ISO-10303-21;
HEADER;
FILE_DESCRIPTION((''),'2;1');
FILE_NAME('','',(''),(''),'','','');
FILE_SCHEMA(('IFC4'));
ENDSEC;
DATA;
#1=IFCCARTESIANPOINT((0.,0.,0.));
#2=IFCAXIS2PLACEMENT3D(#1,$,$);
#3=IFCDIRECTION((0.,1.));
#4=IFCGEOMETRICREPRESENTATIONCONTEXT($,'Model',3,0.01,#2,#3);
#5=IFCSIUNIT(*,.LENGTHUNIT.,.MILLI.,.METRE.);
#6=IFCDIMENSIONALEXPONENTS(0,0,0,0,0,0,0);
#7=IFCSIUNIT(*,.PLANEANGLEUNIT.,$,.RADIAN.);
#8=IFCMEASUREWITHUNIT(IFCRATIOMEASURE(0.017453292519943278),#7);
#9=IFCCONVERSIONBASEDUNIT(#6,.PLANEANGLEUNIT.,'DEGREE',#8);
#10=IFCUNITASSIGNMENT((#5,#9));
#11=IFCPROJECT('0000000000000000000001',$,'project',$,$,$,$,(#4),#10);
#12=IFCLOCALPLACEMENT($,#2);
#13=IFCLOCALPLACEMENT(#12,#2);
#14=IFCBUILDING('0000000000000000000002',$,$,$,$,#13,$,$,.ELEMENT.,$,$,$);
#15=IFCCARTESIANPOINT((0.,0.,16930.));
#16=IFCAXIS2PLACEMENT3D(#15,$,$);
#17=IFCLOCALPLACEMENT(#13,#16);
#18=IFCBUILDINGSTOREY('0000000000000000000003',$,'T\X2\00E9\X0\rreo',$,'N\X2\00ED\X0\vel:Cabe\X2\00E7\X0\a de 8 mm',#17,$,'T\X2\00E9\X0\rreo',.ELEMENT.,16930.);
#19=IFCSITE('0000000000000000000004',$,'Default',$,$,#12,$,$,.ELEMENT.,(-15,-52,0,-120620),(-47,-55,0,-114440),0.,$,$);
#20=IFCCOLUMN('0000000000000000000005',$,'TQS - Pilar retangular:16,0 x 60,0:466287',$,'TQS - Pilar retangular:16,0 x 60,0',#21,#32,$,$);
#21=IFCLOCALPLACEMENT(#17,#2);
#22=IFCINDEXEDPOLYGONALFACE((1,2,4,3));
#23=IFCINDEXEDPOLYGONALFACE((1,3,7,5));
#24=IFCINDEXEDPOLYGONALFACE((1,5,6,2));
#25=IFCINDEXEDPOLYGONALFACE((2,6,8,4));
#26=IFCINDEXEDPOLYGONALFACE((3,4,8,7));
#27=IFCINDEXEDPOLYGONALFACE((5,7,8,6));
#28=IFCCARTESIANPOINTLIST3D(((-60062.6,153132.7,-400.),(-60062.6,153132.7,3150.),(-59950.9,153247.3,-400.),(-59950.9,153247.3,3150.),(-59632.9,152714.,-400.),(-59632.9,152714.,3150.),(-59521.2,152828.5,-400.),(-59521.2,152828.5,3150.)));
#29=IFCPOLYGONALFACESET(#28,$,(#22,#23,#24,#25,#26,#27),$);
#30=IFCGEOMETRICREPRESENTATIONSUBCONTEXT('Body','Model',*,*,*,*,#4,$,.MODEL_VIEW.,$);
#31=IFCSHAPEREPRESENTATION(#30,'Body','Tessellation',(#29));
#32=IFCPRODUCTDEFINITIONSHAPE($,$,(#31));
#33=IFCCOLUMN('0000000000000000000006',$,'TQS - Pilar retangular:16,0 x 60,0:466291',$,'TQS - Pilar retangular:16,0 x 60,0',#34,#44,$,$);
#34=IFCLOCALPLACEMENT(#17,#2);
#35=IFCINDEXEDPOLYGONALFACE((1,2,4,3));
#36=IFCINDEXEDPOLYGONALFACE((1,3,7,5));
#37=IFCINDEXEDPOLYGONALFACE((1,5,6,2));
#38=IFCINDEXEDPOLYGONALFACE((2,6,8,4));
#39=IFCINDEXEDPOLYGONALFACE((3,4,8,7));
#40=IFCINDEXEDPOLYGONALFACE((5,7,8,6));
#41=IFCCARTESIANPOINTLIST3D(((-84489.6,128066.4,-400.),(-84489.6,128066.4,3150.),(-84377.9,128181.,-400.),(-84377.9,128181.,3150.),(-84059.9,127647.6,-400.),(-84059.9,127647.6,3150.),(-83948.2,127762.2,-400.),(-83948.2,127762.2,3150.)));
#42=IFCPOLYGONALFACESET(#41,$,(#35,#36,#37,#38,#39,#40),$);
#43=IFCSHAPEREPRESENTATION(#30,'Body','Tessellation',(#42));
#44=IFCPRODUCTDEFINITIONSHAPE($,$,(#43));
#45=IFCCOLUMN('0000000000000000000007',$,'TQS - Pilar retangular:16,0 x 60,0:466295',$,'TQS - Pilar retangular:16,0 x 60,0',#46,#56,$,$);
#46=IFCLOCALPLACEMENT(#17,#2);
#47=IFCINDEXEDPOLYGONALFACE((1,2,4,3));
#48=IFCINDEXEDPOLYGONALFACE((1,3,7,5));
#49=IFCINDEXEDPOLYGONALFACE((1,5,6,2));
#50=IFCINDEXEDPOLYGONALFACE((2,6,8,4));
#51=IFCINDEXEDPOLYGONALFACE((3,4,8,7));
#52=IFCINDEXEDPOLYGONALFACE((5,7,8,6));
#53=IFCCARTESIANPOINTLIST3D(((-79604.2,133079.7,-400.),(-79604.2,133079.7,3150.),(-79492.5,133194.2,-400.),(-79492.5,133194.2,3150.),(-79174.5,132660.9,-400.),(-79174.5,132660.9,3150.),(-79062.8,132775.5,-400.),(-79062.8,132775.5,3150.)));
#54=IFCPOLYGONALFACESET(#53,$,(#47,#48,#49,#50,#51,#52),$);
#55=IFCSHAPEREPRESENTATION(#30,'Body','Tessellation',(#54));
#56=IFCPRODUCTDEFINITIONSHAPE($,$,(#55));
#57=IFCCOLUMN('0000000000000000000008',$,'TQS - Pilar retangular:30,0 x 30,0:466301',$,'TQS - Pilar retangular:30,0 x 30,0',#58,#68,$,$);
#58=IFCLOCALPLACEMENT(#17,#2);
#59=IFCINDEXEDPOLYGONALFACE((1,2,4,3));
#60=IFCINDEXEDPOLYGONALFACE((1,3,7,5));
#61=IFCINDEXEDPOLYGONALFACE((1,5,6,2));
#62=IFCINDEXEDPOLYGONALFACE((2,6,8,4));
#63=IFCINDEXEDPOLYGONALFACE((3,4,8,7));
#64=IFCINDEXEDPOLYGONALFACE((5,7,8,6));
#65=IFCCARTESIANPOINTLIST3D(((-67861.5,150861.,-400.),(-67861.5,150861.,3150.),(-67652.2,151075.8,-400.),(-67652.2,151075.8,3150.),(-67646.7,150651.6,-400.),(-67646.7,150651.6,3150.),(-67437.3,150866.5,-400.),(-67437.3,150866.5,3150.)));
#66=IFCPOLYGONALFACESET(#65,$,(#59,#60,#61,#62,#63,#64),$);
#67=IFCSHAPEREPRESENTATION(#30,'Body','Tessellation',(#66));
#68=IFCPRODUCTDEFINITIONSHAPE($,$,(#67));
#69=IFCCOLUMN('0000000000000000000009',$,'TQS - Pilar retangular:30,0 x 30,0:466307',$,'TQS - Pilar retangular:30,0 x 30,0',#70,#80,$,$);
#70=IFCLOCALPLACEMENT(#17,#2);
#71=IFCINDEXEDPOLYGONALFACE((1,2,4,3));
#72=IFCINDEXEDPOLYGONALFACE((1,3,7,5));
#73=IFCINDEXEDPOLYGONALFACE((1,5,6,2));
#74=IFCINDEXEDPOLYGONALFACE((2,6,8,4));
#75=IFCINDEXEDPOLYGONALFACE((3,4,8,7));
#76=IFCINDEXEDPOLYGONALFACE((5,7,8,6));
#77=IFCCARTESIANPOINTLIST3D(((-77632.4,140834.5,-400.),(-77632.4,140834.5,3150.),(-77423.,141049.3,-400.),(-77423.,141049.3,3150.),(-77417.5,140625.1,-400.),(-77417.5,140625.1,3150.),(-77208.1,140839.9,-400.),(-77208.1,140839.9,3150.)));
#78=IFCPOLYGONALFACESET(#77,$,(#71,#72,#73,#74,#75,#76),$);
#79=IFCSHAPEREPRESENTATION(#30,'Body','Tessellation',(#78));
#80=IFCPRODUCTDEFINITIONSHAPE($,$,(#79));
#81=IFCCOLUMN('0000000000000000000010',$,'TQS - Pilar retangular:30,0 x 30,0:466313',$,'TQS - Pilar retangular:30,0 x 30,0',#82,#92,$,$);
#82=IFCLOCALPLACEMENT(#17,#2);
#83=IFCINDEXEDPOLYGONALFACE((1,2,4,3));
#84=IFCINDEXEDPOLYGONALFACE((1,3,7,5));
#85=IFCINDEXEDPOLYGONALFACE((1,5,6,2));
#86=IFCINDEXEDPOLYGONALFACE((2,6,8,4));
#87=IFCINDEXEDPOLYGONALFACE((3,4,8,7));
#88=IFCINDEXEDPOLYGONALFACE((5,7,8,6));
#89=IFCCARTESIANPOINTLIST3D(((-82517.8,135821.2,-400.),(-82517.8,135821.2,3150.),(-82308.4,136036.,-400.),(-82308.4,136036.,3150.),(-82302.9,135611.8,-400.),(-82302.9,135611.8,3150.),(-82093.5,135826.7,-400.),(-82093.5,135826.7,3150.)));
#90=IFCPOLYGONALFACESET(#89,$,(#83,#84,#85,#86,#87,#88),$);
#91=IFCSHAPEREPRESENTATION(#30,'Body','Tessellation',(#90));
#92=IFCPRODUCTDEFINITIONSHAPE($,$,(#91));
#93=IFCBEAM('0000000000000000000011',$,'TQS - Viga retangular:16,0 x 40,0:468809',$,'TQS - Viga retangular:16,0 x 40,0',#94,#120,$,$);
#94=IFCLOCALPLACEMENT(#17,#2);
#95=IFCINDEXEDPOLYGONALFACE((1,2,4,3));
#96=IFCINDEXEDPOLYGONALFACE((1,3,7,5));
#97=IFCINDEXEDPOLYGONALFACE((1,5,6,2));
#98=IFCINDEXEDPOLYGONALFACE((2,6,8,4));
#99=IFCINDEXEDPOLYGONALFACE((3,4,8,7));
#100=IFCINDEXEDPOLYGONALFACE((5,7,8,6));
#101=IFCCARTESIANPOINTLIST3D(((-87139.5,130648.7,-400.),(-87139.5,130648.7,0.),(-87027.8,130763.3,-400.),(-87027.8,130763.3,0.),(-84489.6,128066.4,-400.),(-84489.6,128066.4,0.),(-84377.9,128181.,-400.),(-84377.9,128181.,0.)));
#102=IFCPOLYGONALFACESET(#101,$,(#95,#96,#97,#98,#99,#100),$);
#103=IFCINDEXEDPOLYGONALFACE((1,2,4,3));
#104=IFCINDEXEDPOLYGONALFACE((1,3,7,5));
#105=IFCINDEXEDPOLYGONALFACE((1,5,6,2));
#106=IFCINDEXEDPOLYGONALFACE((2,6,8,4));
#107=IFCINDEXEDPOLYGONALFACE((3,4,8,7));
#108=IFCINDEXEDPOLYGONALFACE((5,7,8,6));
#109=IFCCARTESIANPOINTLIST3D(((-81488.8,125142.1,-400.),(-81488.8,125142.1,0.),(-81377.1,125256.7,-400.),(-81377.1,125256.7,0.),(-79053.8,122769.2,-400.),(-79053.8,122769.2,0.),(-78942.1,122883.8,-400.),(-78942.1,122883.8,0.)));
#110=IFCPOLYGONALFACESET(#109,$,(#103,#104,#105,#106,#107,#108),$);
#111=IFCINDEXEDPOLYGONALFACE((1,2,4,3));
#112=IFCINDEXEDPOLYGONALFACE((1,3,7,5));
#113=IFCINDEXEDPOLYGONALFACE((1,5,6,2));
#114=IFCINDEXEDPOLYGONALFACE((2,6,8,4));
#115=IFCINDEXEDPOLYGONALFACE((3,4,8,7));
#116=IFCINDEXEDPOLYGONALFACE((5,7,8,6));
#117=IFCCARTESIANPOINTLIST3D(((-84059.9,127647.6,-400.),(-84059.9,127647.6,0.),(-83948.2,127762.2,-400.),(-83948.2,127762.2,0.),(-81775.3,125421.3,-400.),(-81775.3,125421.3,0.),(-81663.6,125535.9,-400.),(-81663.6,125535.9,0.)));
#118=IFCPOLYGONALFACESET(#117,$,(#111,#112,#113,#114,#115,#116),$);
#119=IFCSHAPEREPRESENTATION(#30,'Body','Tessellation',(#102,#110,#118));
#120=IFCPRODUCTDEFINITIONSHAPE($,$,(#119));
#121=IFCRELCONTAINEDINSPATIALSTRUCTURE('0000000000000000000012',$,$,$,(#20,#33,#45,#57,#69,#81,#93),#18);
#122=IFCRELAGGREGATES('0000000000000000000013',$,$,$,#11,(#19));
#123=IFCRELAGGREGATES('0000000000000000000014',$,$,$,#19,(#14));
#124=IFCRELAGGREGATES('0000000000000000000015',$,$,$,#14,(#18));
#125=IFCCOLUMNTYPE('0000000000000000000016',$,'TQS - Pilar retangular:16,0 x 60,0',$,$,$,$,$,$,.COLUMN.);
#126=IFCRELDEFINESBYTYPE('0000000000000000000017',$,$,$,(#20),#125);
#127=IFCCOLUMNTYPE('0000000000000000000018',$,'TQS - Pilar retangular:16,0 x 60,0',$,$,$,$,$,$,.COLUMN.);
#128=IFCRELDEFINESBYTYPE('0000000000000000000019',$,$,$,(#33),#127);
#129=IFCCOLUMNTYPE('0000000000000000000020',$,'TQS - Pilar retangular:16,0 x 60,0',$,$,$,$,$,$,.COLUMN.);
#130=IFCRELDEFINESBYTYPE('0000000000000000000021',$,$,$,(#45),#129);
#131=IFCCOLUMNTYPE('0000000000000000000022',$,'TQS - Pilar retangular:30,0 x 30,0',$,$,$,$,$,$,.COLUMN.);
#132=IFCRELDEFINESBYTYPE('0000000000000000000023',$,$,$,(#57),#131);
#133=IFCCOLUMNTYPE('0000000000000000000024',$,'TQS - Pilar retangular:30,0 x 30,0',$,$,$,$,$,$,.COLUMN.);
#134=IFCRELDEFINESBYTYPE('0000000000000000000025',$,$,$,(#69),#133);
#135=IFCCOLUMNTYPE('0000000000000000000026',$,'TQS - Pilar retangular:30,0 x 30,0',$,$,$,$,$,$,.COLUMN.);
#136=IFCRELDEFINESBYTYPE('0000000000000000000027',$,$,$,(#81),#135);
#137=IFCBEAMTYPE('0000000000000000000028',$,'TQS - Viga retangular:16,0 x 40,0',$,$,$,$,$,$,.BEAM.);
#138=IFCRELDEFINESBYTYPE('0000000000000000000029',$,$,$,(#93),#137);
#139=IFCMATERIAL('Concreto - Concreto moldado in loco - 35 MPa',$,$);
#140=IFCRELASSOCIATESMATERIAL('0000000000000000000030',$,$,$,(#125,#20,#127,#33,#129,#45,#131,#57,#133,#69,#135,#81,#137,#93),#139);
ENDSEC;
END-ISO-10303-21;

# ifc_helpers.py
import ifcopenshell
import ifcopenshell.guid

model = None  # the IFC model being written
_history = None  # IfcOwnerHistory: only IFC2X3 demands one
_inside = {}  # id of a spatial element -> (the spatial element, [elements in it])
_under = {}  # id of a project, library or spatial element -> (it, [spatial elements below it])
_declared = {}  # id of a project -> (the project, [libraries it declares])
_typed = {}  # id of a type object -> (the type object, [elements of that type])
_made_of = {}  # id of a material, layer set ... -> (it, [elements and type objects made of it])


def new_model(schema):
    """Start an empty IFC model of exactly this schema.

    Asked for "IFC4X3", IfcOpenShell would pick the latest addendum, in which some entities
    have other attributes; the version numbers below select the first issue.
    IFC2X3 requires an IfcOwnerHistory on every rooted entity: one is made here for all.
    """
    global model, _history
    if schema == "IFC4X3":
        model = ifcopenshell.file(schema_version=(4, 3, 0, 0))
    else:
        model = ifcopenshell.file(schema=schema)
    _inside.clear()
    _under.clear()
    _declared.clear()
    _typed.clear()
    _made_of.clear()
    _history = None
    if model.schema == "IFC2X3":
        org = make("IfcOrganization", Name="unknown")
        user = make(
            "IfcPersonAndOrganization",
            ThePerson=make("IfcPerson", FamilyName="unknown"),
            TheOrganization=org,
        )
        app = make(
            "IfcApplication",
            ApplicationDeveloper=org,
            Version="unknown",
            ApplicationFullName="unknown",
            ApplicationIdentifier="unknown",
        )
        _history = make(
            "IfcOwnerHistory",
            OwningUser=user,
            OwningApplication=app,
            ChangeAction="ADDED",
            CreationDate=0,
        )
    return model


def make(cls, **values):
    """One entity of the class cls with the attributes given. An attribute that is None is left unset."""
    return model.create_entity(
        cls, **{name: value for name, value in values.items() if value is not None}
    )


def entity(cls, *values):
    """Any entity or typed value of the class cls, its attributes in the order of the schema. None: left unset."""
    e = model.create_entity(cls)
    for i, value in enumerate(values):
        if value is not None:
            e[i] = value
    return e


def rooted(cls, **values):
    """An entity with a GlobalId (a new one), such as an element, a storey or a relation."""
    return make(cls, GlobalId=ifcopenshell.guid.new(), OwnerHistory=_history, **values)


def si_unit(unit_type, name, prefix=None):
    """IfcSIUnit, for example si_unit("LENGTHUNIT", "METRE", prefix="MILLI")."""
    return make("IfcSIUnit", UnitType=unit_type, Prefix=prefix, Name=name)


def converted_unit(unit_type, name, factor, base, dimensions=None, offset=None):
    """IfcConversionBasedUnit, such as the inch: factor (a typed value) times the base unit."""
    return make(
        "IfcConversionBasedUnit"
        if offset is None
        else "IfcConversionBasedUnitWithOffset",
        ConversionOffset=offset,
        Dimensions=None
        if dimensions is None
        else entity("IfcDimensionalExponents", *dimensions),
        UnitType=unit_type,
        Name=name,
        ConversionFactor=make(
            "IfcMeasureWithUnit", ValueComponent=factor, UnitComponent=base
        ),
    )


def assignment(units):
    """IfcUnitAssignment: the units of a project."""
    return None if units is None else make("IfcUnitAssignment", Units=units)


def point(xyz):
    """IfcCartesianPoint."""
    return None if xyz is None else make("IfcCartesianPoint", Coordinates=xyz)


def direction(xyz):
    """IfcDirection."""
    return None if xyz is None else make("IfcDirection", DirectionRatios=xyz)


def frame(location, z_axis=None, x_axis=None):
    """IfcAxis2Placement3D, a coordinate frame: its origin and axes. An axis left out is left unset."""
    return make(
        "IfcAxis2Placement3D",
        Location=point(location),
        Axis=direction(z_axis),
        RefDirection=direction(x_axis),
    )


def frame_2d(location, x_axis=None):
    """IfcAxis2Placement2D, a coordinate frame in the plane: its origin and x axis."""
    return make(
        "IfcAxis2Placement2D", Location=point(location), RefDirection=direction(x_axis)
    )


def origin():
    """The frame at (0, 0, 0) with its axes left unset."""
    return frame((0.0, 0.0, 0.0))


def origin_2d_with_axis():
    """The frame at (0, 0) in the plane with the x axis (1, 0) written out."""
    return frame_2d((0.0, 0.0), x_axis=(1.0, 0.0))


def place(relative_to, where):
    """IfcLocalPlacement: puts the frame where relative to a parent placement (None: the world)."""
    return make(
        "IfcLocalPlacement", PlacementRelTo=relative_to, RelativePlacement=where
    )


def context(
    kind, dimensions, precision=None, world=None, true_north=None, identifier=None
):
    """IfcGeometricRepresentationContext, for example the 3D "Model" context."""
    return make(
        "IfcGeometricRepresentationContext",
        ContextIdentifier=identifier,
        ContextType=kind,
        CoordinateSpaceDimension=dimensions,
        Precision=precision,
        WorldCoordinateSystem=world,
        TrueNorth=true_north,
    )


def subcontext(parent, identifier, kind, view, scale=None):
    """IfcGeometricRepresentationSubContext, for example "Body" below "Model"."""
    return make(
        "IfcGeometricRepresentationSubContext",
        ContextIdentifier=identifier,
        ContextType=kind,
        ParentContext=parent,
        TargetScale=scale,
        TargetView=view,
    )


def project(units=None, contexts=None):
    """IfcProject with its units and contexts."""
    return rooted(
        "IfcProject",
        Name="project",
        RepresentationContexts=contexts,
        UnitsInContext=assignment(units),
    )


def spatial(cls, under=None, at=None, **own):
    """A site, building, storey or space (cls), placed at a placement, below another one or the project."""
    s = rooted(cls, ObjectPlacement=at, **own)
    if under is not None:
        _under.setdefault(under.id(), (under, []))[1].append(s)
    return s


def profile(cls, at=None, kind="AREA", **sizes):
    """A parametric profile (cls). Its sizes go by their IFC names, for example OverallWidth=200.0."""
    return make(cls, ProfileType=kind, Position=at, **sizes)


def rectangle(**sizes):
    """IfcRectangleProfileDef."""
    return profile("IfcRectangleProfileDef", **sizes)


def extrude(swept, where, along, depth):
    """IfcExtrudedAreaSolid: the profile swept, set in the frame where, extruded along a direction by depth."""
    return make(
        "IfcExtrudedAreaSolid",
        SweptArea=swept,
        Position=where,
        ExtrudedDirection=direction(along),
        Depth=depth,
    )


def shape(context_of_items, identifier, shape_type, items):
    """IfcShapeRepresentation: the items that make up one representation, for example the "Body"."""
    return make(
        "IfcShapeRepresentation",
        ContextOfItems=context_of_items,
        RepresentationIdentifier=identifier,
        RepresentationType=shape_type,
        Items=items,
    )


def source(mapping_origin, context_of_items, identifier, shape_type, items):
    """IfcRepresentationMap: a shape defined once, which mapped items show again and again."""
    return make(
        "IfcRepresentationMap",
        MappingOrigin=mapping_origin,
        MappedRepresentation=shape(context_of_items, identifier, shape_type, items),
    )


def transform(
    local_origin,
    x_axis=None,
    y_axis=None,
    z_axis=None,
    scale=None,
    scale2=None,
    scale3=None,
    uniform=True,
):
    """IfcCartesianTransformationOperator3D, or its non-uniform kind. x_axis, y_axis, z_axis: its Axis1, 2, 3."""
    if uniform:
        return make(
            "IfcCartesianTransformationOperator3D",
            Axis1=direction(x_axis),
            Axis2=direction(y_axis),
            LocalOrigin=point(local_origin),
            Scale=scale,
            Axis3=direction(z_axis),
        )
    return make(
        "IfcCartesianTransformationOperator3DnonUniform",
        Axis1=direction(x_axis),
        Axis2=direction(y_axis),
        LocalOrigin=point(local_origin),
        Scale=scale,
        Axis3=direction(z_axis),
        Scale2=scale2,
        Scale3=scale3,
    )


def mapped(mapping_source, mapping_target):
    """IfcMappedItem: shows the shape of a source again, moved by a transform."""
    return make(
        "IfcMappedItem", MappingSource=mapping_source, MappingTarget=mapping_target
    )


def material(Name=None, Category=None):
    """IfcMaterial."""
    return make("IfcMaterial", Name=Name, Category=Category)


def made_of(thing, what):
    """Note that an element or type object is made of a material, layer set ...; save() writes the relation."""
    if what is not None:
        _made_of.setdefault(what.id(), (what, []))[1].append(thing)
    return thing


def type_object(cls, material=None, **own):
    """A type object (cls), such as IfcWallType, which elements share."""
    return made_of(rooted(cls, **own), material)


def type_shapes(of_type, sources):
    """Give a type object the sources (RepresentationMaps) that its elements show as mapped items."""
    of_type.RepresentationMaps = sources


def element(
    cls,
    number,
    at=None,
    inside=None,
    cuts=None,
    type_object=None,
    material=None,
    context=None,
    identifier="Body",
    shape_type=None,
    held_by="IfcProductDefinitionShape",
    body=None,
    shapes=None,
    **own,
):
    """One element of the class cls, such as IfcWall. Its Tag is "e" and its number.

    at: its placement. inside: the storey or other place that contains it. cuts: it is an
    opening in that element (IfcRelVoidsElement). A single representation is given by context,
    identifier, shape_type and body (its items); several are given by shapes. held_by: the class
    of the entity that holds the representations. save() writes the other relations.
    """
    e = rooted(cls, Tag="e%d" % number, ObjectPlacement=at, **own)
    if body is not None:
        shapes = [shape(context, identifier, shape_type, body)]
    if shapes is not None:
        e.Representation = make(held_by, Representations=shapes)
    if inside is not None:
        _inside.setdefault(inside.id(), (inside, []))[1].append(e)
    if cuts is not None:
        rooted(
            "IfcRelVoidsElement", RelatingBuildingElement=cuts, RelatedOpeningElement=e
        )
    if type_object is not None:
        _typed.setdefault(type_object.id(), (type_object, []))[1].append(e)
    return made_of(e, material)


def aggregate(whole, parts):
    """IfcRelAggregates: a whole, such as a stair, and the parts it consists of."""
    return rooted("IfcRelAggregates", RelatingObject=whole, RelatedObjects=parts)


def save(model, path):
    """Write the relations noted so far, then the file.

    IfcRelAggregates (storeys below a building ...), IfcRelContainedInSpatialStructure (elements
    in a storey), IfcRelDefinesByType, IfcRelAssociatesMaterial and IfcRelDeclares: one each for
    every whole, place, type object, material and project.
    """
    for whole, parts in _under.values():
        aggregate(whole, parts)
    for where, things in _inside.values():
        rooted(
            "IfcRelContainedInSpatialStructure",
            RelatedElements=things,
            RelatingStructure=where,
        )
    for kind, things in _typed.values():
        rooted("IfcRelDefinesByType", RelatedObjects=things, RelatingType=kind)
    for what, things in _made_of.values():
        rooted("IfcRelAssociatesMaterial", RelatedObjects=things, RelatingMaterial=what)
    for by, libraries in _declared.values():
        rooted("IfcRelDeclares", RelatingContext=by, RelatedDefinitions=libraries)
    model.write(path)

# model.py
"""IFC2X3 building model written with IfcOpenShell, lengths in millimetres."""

from ifc_helpers import new_model, entity, si_unit, converted_unit, direction, frame, frame_2d, origin, origin_2d_with_axis, place, context, subcontext, project, spatial, rectangle, extrude, source, transform, mapped, material, type_object, type_shapes, element, save


model = new_model("IFC2X3")

# Units and contexts
model_context = context("Model", 3, precision=0.01, world=origin(), true_north=direction((0.0, 1.0)))
body_context = subcontext(model_context, "Body", "Model", "MODEL_VIEW")
ifc_project = project(units=[si_unit("LENGTHUNIT", "METRE", prefix="MILLI"), converted_unit("PLANEANGLEUNIT", "DEGREE", entity("IfcRatioMeasure", 0.017453292519943278), si_unit("PLANEANGLEUNIT", "RADIAN"), dimensions=[0, 0, 0, 0, 0, 0, 0])], contexts=[model_context])

# Site, building, storey
site_placement = place(None, origin())
site = spatial("IfcSite", under=ifc_project, at=site_placement, Name="Default", CompositionType="ELEMENT", RefLatitude=(-15, -52, 0, -120620), RefLongitude=(-47, -55, 0, -114440), RefElevation=0.0)
building_placement = place(site_placement, origin())
building = spatial("IfcBuilding", under=site, at=building_placement, CompositionType="ELEMENT")
storey_placement = place(building_placement, frame((0.0, 0.0, 16930.0)))
storey = spatial("IfcBuildingStorey", under=building, at=storey_placement, Name="Térreo", ObjectType="Nível:Cabeça de 8 mm", LongName="Térreo", CompositionType="ELEMENT", Elevation=16930.0)

# Columns
ifc_material = material(Name="Concreto - Concreto moldado in loco - 35 MPa")
column_type_1 = type_object("IfcColumnType", Name="TQS - Pilar retangular:16,0 x 60,0", PredefinedType="COLUMN", material=ifc_material)
shared_shape_1 = source(origin(), body_context, "Body", "SweptSolid", [
    extrude(rectangle(XDim=600.0, YDim=160.0, at=frame_2d((0.0, 0.0), x_axis=(1.0, 0.0))), frame((-59791.9, 152980.6, 16530.0), z_axis=(0.0, 0.0, 1.0), x_axis=(-0.71618, 0.697915, 0.0)), (0.0, 0.0, 1.0), 3550.0),
])
type_shapes(column_type_1, [shared_shape_1])
column_1_placement = place(storey_placement, frame((0.0, 0.0, -16930.0)))
element("IfcColumn", 1, at=column_1_placement, inside=storey, type_object=column_type_1, material=ifc_material, Name="TQS - Pilar retangular:16,0 x 60,0:466287", ObjectType="TQS - Pilar retangular:16,0 x 60,0", context=body_context, shape_type="MappedRepresentation", body=[
    mapped(shared_shape_1, transform((0.0, 0.0, 0.0), scale=1.0)),
])
column_type_2 = type_object("IfcColumnType", Name="TQS - Pilar retangular:16,0 x 60,0", PredefinedType="COLUMN", material=ifc_material)
shared_shape_2 = source(origin(), body_context, "Body", "SweptSolid", [
    extrude(rectangle(XDim=600.0, YDim=160.0, at=frame_2d((0.0, 0.0), x_axis=(1.0, 0.0))), frame((-84218.9, 127914.3, 16530.0), z_axis=(0.0, 0.0, 1.0), x_axis=(-0.71618, 0.697915, 0.0)), (0.0, 0.0, 1.0), 3550.0),
])
type_shapes(column_type_2, [shared_shape_2])
column_2_placement = place(storey_placement, frame((0.0, 0.0, -16930.0)))
element("IfcColumn", 2, at=column_2_placement, inside=storey, type_object=column_type_2, material=ifc_material, Name="TQS - Pilar retangular:16,0 x 60,0:466291", ObjectType="TQS - Pilar retangular:16,0 x 60,0", context=body_context, shape_type="MappedRepresentation", body=[
    mapped(shared_shape_2, transform((0.0, 0.0, 0.0), scale=1.0)),
])
column_type_3 = type_object("IfcColumnType", Name="TQS - Pilar retangular:16,0 x 60,0", PredefinedType="COLUMN", material=ifc_material)
shared_shape_3 = source(origin(), body_context, "Body", "SweptSolid", [
    extrude(rectangle(XDim=600.0, YDim=160.0, at=frame_2d((0.0, 0.0), x_axis=(1.0, 0.0))), frame((-79333.5, 132927.6, 16530.0), z_axis=(0.0, 0.0, 1.0), x_axis=(-0.71618, 0.697915, 0.0)), (0.0, 0.0, 1.0), 3550.0),
])
type_shapes(column_type_3, [shared_shape_3])
column_3_placement = place(storey_placement, frame((0.0, 0.0, -16930.0)))
element("IfcColumn", 3, at=column_3_placement, inside=storey, type_object=column_type_3, material=ifc_material, Name="TQS - Pilar retangular:16,0 x 60,0:466295", ObjectType="TQS - Pilar retangular:16,0 x 60,0", context=body_context, shape_type="MappedRepresentation", body=[
    mapped(shared_shape_3, transform((0.0, 0.0, 0.0), scale=1.0)),
])
column_type_4 = type_object("IfcColumnType", Name="TQS - Pilar retangular:30,0 x 30,0", PredefinedType="COLUMN", material=ifc_material)
shared_shape_4 = source(origin(), body_context, "Body", "SweptSolid", [
    extrude(rectangle(XDim=300.0, YDim=300.0, at=origin_2d_with_axis()), frame((-67649.4, 150863.7, 16530.0), z_axis=(0.0, 0.0, 1.0), x_axis=(-0.71618, 0.697915, 0.0)), (0.0, 0.0, 1.0), 3550.0),
])
type_shapes(column_type_4, [shared_shape_4])
column_4_placement = place(storey_placement, frame((0.0, 0.0, -16930.0)))
element("IfcColumn", 4, at=column_4_placement, inside=storey, type_object=column_type_4, material=ifc_material, Name="TQS - Pilar retangular:30,0 x 30,0:466301", ObjectType="TQS - Pilar retangular:30,0 x 30,0", context=body_context, shape_type="MappedRepresentation", body=[
    mapped(shared_shape_4, transform((0.0, 0.0, 0.0), scale=1.0)),
])
column_type_5 = type_object("IfcColumnType", Name="TQS - Pilar retangular:30,0 x 30,0", PredefinedType="COLUMN", material=ifc_material)
shared_shape_5 = source(origin(), body_context, "Body", "SweptSolid", [
    extrude(rectangle(XDim=300.0, YDim=300.0, at=origin_2d_with_axis()), frame((-77420.2, 140837.2, 16530.0), z_axis=(0.0, 0.0, 1.0), x_axis=(-0.71618, 0.697915, 0.0)), (0.0, 0.0, 1.0), 3550.0),
])
type_shapes(column_type_5, [shared_shape_5])
column_5_placement = place(storey_placement, frame((0.0, 0.0, -16930.0)))
element("IfcColumn", 5, at=column_5_placement, inside=storey, type_object=column_type_5, material=ifc_material, Name="TQS - Pilar retangular:30,0 x 30,0:466307", ObjectType="TQS - Pilar retangular:30,0 x 30,0", context=body_context, shape_type="MappedRepresentation", body=[
    mapped(shared_shape_5, transform((0.0, 0.0, 0.0), scale=1.0)),
])
column_type_6 = type_object("IfcColumnType", Name="TQS - Pilar retangular:30,0 x 30,0", PredefinedType="COLUMN", material=ifc_material)
shared_shape_6 = source(origin(), body_context, "Body", "SweptSolid", [
    extrude(rectangle(XDim=300.0, YDim=300.0, at=origin_2d_with_axis()), frame((-82305.7, 135823.9, 16530.0), z_axis=(0.0, 0.0, 1.0), x_axis=(-0.71618, 0.697915, 0.0)), (0.0, 0.0, 1.0), 3550.0),
])
type_shapes(column_type_6, [shared_shape_6])
column_6_placement = place(storey_placement, frame((0.0, 0.0, -16930.0)))
element("IfcColumn", 6, at=column_6_placement, inside=storey, type_object=column_type_6, material=ifc_material, Name="TQS - Pilar retangular:30,0 x 30,0:466313", ObjectType="TQS - Pilar retangular:30,0 x 30,0", context=body_context, shape_type="MappedRepresentation", body=[
    mapped(shared_shape_6, transform((0.0, 0.0, 0.0), scale=1.0)),
])

# Beam
beam_type = type_object("IfcBeamType", Name="TQS - Viga retangular:16,0 x 40,0", PredefinedType="BEAM", material=ifc_material)
shared_shape_7 = source(origin(), body_context, "Body", "SweptSolid", [
    extrude(rectangle(XDim=400.0, YDim=160.0, at=origin_2d_with_axis()), frame((-84433.8, 128123.7, 16730.0), z_axis=(-0.71618, 0.697915, 0.0), x_axis=(0.0, 0.0, 1.0)), (0.0, 0.0, 1.0), 3700.0),
    extrude(rectangle(XDim=400.0, YDim=160.0, at=frame_2d((0.0, 0.0), x_axis=(1.0, 0.0))), frame((-78998.0, 122826.5, 16730.0), z_axis=(-0.71618, 0.697915, 0.0), x_axis=(0.0, 0.0, 1.0)), (0.0, 0.0, 1.0), 3400.0),
    extrude(rectangle(XDim=400.0, YDim=160.0, at=frame_2d((0.0, 0.0), x_axis=(1.0, 0.0))), frame((-81719.5, 125478.6, 16730.0), z_axis=(-0.71618, 0.697915, 0.0), x_axis=(0.0, 0.0, 1.0)), (0.0, 0.0, 1.0), 3190.0),
])
type_shapes(beam_type, [shared_shape_7])
beam_placement = place(storey_placement, frame((0.0, 0.0, -16930.0)))
element("IfcBeam", 7, at=beam_placement, inside=storey, type_object=beam_type, material=ifc_material, Name="TQS - Viga retangular:16,0 x 40,0:468809", ObjectType="TQS - Viga retangular:16,0 x 40,0", context=body_context, shape_type="MappedRepresentation", body=[
    mapped(shared_shape_7, transform((0.0, 0.0, 0.0), scale=1.0)),
])

save(model, "model.ifc")
